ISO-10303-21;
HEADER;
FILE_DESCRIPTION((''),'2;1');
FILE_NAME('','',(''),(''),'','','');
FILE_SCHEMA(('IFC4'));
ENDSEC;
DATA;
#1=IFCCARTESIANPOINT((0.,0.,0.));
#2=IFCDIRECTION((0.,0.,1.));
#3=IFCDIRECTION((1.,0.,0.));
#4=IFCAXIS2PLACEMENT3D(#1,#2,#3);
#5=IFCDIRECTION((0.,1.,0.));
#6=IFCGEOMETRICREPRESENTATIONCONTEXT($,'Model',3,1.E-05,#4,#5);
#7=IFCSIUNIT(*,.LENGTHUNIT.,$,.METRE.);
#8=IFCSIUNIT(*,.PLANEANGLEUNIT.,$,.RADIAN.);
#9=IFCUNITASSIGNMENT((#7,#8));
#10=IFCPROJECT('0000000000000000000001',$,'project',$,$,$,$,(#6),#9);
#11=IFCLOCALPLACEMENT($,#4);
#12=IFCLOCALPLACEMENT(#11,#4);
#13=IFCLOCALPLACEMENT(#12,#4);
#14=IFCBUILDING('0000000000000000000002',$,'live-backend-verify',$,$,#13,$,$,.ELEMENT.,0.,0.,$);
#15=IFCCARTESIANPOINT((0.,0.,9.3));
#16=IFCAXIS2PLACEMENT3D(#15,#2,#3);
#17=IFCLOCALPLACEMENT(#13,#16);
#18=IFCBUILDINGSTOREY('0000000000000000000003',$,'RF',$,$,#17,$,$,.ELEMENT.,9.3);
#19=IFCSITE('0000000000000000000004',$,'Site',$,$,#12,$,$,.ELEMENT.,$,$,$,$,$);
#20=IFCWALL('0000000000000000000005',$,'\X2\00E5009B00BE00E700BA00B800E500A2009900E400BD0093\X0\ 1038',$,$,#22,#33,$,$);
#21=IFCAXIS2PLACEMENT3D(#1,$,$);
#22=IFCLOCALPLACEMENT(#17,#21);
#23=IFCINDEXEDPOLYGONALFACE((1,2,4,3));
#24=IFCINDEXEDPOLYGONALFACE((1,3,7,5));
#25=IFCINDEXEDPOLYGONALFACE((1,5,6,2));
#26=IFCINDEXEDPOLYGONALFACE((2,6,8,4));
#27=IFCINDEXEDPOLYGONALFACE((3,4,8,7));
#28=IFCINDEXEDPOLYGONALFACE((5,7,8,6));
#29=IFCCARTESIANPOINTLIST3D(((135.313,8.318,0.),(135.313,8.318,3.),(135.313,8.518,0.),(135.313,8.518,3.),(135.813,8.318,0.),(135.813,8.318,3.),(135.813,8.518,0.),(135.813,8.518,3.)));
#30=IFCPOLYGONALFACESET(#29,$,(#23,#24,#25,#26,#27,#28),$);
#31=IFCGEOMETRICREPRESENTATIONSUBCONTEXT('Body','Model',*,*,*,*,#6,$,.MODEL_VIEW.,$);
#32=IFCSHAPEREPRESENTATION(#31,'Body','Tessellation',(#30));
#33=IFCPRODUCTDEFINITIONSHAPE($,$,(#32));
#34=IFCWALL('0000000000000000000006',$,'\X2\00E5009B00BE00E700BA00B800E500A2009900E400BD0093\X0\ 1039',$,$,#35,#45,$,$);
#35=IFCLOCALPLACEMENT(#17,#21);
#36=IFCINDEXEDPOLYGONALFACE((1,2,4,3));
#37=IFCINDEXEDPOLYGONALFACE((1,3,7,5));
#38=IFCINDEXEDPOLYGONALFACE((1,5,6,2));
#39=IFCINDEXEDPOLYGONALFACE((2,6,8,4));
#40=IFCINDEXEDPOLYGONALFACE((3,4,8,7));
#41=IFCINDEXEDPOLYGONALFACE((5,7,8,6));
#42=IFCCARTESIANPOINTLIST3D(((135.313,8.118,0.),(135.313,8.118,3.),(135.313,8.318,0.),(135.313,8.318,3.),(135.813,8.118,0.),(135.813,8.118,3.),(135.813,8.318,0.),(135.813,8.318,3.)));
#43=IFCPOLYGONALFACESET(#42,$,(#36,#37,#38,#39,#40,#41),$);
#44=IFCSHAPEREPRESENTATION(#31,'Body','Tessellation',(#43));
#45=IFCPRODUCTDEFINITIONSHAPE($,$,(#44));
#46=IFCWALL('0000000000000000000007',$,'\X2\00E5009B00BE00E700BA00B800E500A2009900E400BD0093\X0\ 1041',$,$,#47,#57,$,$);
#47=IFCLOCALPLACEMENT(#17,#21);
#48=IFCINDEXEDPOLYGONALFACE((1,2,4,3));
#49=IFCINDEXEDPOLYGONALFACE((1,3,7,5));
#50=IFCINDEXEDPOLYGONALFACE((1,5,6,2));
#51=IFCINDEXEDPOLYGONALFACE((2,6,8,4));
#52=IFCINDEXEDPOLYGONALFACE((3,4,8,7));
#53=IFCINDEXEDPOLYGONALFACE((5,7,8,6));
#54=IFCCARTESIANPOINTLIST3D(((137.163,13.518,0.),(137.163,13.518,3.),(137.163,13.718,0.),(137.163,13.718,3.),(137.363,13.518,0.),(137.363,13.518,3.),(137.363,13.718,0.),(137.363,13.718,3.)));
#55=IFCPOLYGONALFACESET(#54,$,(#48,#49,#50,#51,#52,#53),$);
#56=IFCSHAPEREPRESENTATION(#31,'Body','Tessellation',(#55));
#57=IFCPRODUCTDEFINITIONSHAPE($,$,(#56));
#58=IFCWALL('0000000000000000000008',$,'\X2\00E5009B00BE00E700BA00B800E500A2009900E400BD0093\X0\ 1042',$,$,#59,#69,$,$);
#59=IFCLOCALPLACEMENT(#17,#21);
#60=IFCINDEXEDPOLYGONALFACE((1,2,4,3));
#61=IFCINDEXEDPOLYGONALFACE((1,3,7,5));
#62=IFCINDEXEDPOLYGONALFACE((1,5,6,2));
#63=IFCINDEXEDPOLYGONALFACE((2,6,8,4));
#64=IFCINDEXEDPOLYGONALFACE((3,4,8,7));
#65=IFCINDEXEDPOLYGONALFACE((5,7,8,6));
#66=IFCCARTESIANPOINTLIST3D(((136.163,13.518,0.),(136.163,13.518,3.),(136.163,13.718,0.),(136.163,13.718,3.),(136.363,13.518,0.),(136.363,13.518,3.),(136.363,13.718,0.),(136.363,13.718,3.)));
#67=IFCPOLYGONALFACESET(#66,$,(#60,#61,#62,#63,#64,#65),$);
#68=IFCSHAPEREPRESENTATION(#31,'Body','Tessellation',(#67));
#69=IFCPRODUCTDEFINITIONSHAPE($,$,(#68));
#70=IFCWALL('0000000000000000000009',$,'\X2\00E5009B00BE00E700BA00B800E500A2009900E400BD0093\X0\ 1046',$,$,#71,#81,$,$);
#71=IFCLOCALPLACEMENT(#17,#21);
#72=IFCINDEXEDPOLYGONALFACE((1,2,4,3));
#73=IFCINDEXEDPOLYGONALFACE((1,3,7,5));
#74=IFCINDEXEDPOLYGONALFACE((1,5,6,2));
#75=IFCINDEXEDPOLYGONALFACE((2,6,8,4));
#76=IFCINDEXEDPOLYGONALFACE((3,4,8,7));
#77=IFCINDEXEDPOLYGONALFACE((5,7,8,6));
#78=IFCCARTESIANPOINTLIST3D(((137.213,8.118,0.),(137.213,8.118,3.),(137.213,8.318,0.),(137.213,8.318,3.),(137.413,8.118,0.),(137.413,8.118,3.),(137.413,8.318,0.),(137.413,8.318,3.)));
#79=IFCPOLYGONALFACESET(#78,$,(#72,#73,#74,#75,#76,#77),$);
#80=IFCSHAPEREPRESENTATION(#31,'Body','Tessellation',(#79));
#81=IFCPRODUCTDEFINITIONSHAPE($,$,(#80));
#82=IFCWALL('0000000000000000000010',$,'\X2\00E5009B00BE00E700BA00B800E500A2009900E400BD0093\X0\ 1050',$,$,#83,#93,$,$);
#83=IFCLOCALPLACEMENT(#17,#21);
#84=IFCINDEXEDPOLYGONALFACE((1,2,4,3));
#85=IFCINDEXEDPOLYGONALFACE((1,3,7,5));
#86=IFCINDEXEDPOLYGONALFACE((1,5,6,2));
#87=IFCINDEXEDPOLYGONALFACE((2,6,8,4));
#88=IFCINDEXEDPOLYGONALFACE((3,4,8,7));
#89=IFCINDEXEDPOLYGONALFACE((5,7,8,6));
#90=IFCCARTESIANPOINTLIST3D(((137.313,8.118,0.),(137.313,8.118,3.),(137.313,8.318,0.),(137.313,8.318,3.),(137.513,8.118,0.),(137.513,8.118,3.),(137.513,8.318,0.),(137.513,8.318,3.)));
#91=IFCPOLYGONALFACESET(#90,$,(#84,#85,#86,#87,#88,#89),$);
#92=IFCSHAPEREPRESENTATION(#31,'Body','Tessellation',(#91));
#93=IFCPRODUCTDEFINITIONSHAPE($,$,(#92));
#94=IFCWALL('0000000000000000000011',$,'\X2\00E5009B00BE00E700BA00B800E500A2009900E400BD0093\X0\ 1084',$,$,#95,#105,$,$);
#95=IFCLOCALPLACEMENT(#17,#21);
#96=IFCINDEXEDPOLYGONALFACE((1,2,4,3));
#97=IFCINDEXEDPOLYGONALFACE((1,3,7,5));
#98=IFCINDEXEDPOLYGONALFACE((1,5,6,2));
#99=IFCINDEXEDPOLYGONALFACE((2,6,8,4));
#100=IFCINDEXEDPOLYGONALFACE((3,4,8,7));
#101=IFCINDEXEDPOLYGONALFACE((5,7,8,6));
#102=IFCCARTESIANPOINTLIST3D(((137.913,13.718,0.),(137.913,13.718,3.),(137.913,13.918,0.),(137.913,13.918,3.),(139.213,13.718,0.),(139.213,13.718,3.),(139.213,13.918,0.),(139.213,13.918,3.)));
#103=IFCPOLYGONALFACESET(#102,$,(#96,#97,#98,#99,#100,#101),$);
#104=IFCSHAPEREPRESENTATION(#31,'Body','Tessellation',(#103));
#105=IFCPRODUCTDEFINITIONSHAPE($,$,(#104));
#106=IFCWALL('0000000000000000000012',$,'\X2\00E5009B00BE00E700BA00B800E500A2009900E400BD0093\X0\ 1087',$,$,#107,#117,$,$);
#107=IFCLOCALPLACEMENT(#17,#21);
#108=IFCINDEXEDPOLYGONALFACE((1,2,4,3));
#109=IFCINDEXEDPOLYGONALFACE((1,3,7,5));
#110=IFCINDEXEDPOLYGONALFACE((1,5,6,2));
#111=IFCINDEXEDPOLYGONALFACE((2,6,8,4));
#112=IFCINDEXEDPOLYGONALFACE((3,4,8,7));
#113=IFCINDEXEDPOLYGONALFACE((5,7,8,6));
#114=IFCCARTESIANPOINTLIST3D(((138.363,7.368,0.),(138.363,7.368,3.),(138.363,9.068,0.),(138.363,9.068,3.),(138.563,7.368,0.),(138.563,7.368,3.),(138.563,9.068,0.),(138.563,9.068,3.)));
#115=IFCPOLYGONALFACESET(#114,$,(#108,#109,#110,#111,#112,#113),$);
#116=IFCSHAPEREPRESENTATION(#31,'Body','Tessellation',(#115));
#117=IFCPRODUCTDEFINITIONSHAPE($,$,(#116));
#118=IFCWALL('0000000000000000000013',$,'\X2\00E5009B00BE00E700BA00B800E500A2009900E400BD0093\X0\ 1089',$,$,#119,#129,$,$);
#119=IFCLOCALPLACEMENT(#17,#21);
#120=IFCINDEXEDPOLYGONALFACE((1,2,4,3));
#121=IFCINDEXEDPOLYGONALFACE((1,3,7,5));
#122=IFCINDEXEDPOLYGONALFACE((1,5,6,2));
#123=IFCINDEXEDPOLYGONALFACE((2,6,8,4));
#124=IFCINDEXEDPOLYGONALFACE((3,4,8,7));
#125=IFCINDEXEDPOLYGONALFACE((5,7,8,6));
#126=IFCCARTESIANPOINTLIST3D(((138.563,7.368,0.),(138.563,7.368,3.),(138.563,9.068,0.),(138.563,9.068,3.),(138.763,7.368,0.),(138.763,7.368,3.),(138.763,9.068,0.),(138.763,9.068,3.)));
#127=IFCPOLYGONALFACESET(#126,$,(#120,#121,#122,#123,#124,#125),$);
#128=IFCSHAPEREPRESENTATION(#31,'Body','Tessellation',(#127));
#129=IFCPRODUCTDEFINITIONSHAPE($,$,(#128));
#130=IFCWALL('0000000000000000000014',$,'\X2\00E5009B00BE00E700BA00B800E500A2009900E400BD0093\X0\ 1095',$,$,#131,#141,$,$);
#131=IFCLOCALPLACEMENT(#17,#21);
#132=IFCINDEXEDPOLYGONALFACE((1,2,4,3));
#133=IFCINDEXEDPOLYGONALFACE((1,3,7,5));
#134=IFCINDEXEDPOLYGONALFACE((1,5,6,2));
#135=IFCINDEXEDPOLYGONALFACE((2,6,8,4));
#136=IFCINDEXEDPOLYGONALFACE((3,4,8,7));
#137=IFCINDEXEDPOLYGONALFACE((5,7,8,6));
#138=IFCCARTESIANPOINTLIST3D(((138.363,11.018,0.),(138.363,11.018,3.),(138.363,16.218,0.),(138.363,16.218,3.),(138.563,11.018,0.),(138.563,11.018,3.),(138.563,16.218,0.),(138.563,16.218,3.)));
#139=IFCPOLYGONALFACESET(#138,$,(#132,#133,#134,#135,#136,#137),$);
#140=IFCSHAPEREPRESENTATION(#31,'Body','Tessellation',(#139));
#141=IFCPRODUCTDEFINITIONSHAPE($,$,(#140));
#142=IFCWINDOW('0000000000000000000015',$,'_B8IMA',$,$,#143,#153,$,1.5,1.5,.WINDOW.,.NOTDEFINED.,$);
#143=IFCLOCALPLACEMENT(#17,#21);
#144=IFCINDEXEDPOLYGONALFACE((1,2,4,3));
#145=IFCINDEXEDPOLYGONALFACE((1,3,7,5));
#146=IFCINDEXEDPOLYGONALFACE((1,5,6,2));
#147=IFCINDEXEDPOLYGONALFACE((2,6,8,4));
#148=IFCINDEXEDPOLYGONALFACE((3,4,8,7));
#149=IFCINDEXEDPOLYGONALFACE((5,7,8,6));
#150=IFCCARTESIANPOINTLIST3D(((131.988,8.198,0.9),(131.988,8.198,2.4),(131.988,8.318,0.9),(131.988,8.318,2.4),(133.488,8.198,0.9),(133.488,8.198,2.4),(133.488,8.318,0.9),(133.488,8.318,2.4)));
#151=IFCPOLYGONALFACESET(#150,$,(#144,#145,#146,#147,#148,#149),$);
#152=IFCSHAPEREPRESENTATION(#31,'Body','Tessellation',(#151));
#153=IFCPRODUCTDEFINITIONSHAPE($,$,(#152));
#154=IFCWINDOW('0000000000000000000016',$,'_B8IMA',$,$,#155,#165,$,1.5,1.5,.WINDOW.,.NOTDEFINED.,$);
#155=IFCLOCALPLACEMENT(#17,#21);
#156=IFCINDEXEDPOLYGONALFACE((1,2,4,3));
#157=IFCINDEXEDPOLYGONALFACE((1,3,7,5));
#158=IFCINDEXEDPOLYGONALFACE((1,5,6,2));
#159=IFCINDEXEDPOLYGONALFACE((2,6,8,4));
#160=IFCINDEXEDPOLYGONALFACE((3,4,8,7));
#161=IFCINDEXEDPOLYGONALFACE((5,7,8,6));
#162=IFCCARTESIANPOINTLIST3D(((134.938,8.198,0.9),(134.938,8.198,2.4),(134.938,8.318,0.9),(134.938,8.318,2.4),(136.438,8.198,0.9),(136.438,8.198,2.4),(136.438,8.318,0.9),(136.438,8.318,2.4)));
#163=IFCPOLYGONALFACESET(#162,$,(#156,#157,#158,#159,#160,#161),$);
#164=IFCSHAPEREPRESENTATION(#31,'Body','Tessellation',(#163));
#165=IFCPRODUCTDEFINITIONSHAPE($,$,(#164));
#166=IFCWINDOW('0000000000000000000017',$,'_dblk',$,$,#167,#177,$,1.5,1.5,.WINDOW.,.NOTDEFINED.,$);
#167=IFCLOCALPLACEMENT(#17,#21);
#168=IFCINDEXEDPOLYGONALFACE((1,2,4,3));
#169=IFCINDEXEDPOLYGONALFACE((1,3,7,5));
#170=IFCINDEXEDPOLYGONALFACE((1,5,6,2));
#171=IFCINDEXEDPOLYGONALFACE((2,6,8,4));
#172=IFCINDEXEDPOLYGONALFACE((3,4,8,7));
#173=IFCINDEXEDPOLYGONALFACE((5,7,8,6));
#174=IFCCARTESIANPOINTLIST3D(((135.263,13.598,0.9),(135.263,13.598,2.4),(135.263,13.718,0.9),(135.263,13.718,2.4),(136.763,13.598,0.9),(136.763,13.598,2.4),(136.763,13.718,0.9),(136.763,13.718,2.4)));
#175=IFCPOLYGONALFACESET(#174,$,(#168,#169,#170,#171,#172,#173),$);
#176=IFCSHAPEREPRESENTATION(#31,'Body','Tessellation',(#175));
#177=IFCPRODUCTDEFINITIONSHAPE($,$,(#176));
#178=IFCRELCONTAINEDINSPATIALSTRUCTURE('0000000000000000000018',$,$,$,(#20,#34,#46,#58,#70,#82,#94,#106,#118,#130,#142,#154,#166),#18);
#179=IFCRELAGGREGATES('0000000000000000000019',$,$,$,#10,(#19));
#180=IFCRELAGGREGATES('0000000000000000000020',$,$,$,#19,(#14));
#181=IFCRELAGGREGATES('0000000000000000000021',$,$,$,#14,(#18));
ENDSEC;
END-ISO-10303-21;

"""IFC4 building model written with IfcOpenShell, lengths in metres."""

from ifc_helpers import new_model, si_unit, direction, frame, frame_2d, origin_with_axes, place, context, subcontext, project, spatial, rectangle, extrude, element, save


model = new_model("IFC4")

# Units and contexts
model_context = context("Model", 3, precision=1e-05, world=origin_with_axes(), true_north=direction((0.0, 1.0, 0.0)))
body_context = subcontext(model_context, "Body", "Model", "MODEL_VIEW")
ifc_project = project(units=[si_unit("LENGTHUNIT", "METRE"), si_unit("PLANEANGLEUNIT", "RADIAN")], contexts=[model_context])

# Site, building, storey
placement = place(None, origin_with_axes())
site_placement = place(placement, origin_with_axes())
site = spatial("IfcSite", under=ifc_project, at=site_placement, Name="Site", CompositionType="ELEMENT")
building_placement = place(site_placement, origin_with_axes())
building = spatial("IfcBuilding", under=site, at=building_placement, Name="live-backend-verify", CompositionType="ELEMENT", ElevationOfRefHeight=0.0, ElevationOfTerrain=0.0)
storey_placement = place(building_placement, frame((0.0, 0.0, 9.3), z_axis=(0.0, 0.0, 1.0), x_axis=(1.0, 0.0, 0.0)))
storey = spatial("IfcBuildingStorey", under=building, at=storey_placement, Name="RF", CompositionType="ELEMENT", Elevation=9.3)

# Walls
for number, where, z_axis, x_axis, name in (
    (1, (135.563, 8.418, 0.0), (0.0, 0.0, 1.0), (-1.0, 0.0, 0.0), "å\u009b¾çº¸å¢\u0099ä½\u0093 1038"),
    (2, (135.563, 8.218, 0.0), (0.0, 0.0, 1.0), (-1.0, 0.0, 0.0), "å\u009b¾çº¸å¢\u0099ä½\u0093 1039"),
):
    element("IfcWall", number, at=place(storey_placement, frame(where, z_axis=z_axis, x_axis=x_axis)), inside=storey, Name=name, context=body_context, shape_type="SweptSolid", body=[
        extrude(rectangle(XDim=0.5, YDim=0.2, at=frame_2d((0.0, 0.0), x_axis=(1.0, 0.0, 0.0))), frame((0.0, 0.0, 0.0), z_axis=(0.0, 0.0, 1.0)), (0.0, 0.0, 1.0), 3.0),
    ])
for number, where, z_axis, x_axis, name in (
    (3, (137.263, 13.618, 0.0), (0.0, 0.0, 1.0), (0.0, 1.0, 0.0), "å\u009b¾çº¸å¢\u0099ä½\u0093 1041"),
    (4, (136.263, 13.618, 0.0), (0.0, 0.0, 1.0), (0.0, 1.0, 0.0), "å\u009b¾çº¸å¢\u0099ä½\u0093 1042"),
    (5, (137.313, 8.218, 0.0), (0.0, 0.0, 1.0), (0.0, 1.0, 0.0), "å\u009b¾çº¸å¢\u0099ä½\u0093 1046"),
    (6, (137.413, 8.218, 0.0), (0.0, 0.0, 1.0), (0.0, -1.0, 0.0), "å\u009b¾çº¸å¢\u0099ä½\u0093 1050"),
):
    element("IfcWall", number, at=place(storey_placement, frame(where, z_axis=z_axis, x_axis=x_axis)), inside=storey, Name=name, context=body_context, shape_type="SweptSolid", body=[
        extrude(rectangle(XDim=0.2, YDim=0.2, at=frame_2d((0.0, 0.0), x_axis=(1.0, 0.0, 0.0))), frame((0.0, 0.0, 0.0), z_axis=(0.0, 0.0, 1.0)), (0.0, 0.0, 1.0), 3.0),
    ])
wall_1_placement = place(storey_placement, frame((138.563, 13.818, 0.0), z_axis=(0.0, 0.0, 1.0), x_axis=(1.0, 0.0, 0.0)))
element("IfcWall", 7, at=wall_1_placement, inside=storey, Name="å\u009b¾çº¸å¢\u0099ä½\u0093 1084", context=body_context, shape_type="SweptSolid", body=[
    extrude(rectangle(XDim=1.3, YDim=0.2, at=frame_2d((0.0, 0.0), x_axis=(1.0, 0.0, 0.0))), frame((0.0, 0.0, 0.0), z_axis=(0.0, 0.0, 1.0)), (0.0, 0.0, 1.0), 3.0),
])
for number, where, z_axis, x_axis, name in (
    (8, (138.463, 8.218, 0.0), (0.0, 0.0, 1.0), (0.0, -1.0, 0.0), "å\u009b¾çº¸å¢\u0099ä½\u0093 1087"),
    (9, (138.663, 8.218, 0.0), (0.0, 0.0, 1.0), (0.0, -1.0, 0.0), "å\u009b¾çº¸å¢\u0099ä½\u0093 1089"),
):
    element("IfcWall", number, at=place(storey_placement, frame(where, z_axis=z_axis, x_axis=x_axis)), inside=storey, Name=name, context=body_context, shape_type="SweptSolid", body=[
        extrude(rectangle(XDim=1.7, YDim=0.2, at=frame_2d((0.0, 0.0), x_axis=(1.0, 0.0, 0.0))), frame((0.0, 0.0, 0.0), z_axis=(0.0, 0.0, 1.0)), (0.0, 0.0, 1.0), 3.0),
    ])
wall_2_placement = place(storey_placement, frame((138.463, 13.618, 0.0), z_axis=(0.0, 0.0, 1.0), x_axis=(0.0, -1.0, 0.0)))
element("IfcWall", 10, at=wall_2_placement, inside=storey, Name="å\u009b¾çº¸å¢\u0099ä½\u0093 1095", context=body_context, shape_type="SweptSolid", body=[
    extrude(rectangle(XDim=5.2, YDim=0.2, at=frame_2d((0.0, 0.0), x_axis=(1.0, 0.0, 0.0))), frame((0.0, 0.0, 0.0), z_axis=(0.0, 0.0, 1.0)), (0.0, 0.0, 1.0), 3.0),
])

# Windows
for number, where, z_axis, x_axis, name in (
    (11, (132.738, 8.258, 0.9), (0.0, 0.0, 1.0), (1.0, 0.0, 0.0), "_B8IMA"),
    (12, (135.688, 8.258, 0.9), (0.0, 0.0, 1.0), (1.0, 0.0, 0.0), "_B8IMA"),
    (13, (136.013, 13.658, 0.9), (0.0, 0.0, 1.0), (1.0, 0.0, 0.0), "_dblk"),
):
    element("IfcWindow", number, at=place(storey_placement, frame(where, z_axis=z_axis, x_axis=x_axis)), inside=storey, Name=name, OverallHeight=1.5, OverallWidth=1.5, PartitioningType="NOTDEFINED", PredefinedType="WINDOW", context=body_context, shape_type="SweptSolid", body=[
        extrude(rectangle(XDim=1.5, YDim=0.12, at=frame_2d((0.0, 0.0), x_axis=(1.0, 0.0, 0.0))), frame((0.0, 0.0, 0.0), z_axis=(0.0, 0.0, 1.0)), (0.0, 0.0, 1.0), 1.5),
    ])

save(model, "model.ifc")
